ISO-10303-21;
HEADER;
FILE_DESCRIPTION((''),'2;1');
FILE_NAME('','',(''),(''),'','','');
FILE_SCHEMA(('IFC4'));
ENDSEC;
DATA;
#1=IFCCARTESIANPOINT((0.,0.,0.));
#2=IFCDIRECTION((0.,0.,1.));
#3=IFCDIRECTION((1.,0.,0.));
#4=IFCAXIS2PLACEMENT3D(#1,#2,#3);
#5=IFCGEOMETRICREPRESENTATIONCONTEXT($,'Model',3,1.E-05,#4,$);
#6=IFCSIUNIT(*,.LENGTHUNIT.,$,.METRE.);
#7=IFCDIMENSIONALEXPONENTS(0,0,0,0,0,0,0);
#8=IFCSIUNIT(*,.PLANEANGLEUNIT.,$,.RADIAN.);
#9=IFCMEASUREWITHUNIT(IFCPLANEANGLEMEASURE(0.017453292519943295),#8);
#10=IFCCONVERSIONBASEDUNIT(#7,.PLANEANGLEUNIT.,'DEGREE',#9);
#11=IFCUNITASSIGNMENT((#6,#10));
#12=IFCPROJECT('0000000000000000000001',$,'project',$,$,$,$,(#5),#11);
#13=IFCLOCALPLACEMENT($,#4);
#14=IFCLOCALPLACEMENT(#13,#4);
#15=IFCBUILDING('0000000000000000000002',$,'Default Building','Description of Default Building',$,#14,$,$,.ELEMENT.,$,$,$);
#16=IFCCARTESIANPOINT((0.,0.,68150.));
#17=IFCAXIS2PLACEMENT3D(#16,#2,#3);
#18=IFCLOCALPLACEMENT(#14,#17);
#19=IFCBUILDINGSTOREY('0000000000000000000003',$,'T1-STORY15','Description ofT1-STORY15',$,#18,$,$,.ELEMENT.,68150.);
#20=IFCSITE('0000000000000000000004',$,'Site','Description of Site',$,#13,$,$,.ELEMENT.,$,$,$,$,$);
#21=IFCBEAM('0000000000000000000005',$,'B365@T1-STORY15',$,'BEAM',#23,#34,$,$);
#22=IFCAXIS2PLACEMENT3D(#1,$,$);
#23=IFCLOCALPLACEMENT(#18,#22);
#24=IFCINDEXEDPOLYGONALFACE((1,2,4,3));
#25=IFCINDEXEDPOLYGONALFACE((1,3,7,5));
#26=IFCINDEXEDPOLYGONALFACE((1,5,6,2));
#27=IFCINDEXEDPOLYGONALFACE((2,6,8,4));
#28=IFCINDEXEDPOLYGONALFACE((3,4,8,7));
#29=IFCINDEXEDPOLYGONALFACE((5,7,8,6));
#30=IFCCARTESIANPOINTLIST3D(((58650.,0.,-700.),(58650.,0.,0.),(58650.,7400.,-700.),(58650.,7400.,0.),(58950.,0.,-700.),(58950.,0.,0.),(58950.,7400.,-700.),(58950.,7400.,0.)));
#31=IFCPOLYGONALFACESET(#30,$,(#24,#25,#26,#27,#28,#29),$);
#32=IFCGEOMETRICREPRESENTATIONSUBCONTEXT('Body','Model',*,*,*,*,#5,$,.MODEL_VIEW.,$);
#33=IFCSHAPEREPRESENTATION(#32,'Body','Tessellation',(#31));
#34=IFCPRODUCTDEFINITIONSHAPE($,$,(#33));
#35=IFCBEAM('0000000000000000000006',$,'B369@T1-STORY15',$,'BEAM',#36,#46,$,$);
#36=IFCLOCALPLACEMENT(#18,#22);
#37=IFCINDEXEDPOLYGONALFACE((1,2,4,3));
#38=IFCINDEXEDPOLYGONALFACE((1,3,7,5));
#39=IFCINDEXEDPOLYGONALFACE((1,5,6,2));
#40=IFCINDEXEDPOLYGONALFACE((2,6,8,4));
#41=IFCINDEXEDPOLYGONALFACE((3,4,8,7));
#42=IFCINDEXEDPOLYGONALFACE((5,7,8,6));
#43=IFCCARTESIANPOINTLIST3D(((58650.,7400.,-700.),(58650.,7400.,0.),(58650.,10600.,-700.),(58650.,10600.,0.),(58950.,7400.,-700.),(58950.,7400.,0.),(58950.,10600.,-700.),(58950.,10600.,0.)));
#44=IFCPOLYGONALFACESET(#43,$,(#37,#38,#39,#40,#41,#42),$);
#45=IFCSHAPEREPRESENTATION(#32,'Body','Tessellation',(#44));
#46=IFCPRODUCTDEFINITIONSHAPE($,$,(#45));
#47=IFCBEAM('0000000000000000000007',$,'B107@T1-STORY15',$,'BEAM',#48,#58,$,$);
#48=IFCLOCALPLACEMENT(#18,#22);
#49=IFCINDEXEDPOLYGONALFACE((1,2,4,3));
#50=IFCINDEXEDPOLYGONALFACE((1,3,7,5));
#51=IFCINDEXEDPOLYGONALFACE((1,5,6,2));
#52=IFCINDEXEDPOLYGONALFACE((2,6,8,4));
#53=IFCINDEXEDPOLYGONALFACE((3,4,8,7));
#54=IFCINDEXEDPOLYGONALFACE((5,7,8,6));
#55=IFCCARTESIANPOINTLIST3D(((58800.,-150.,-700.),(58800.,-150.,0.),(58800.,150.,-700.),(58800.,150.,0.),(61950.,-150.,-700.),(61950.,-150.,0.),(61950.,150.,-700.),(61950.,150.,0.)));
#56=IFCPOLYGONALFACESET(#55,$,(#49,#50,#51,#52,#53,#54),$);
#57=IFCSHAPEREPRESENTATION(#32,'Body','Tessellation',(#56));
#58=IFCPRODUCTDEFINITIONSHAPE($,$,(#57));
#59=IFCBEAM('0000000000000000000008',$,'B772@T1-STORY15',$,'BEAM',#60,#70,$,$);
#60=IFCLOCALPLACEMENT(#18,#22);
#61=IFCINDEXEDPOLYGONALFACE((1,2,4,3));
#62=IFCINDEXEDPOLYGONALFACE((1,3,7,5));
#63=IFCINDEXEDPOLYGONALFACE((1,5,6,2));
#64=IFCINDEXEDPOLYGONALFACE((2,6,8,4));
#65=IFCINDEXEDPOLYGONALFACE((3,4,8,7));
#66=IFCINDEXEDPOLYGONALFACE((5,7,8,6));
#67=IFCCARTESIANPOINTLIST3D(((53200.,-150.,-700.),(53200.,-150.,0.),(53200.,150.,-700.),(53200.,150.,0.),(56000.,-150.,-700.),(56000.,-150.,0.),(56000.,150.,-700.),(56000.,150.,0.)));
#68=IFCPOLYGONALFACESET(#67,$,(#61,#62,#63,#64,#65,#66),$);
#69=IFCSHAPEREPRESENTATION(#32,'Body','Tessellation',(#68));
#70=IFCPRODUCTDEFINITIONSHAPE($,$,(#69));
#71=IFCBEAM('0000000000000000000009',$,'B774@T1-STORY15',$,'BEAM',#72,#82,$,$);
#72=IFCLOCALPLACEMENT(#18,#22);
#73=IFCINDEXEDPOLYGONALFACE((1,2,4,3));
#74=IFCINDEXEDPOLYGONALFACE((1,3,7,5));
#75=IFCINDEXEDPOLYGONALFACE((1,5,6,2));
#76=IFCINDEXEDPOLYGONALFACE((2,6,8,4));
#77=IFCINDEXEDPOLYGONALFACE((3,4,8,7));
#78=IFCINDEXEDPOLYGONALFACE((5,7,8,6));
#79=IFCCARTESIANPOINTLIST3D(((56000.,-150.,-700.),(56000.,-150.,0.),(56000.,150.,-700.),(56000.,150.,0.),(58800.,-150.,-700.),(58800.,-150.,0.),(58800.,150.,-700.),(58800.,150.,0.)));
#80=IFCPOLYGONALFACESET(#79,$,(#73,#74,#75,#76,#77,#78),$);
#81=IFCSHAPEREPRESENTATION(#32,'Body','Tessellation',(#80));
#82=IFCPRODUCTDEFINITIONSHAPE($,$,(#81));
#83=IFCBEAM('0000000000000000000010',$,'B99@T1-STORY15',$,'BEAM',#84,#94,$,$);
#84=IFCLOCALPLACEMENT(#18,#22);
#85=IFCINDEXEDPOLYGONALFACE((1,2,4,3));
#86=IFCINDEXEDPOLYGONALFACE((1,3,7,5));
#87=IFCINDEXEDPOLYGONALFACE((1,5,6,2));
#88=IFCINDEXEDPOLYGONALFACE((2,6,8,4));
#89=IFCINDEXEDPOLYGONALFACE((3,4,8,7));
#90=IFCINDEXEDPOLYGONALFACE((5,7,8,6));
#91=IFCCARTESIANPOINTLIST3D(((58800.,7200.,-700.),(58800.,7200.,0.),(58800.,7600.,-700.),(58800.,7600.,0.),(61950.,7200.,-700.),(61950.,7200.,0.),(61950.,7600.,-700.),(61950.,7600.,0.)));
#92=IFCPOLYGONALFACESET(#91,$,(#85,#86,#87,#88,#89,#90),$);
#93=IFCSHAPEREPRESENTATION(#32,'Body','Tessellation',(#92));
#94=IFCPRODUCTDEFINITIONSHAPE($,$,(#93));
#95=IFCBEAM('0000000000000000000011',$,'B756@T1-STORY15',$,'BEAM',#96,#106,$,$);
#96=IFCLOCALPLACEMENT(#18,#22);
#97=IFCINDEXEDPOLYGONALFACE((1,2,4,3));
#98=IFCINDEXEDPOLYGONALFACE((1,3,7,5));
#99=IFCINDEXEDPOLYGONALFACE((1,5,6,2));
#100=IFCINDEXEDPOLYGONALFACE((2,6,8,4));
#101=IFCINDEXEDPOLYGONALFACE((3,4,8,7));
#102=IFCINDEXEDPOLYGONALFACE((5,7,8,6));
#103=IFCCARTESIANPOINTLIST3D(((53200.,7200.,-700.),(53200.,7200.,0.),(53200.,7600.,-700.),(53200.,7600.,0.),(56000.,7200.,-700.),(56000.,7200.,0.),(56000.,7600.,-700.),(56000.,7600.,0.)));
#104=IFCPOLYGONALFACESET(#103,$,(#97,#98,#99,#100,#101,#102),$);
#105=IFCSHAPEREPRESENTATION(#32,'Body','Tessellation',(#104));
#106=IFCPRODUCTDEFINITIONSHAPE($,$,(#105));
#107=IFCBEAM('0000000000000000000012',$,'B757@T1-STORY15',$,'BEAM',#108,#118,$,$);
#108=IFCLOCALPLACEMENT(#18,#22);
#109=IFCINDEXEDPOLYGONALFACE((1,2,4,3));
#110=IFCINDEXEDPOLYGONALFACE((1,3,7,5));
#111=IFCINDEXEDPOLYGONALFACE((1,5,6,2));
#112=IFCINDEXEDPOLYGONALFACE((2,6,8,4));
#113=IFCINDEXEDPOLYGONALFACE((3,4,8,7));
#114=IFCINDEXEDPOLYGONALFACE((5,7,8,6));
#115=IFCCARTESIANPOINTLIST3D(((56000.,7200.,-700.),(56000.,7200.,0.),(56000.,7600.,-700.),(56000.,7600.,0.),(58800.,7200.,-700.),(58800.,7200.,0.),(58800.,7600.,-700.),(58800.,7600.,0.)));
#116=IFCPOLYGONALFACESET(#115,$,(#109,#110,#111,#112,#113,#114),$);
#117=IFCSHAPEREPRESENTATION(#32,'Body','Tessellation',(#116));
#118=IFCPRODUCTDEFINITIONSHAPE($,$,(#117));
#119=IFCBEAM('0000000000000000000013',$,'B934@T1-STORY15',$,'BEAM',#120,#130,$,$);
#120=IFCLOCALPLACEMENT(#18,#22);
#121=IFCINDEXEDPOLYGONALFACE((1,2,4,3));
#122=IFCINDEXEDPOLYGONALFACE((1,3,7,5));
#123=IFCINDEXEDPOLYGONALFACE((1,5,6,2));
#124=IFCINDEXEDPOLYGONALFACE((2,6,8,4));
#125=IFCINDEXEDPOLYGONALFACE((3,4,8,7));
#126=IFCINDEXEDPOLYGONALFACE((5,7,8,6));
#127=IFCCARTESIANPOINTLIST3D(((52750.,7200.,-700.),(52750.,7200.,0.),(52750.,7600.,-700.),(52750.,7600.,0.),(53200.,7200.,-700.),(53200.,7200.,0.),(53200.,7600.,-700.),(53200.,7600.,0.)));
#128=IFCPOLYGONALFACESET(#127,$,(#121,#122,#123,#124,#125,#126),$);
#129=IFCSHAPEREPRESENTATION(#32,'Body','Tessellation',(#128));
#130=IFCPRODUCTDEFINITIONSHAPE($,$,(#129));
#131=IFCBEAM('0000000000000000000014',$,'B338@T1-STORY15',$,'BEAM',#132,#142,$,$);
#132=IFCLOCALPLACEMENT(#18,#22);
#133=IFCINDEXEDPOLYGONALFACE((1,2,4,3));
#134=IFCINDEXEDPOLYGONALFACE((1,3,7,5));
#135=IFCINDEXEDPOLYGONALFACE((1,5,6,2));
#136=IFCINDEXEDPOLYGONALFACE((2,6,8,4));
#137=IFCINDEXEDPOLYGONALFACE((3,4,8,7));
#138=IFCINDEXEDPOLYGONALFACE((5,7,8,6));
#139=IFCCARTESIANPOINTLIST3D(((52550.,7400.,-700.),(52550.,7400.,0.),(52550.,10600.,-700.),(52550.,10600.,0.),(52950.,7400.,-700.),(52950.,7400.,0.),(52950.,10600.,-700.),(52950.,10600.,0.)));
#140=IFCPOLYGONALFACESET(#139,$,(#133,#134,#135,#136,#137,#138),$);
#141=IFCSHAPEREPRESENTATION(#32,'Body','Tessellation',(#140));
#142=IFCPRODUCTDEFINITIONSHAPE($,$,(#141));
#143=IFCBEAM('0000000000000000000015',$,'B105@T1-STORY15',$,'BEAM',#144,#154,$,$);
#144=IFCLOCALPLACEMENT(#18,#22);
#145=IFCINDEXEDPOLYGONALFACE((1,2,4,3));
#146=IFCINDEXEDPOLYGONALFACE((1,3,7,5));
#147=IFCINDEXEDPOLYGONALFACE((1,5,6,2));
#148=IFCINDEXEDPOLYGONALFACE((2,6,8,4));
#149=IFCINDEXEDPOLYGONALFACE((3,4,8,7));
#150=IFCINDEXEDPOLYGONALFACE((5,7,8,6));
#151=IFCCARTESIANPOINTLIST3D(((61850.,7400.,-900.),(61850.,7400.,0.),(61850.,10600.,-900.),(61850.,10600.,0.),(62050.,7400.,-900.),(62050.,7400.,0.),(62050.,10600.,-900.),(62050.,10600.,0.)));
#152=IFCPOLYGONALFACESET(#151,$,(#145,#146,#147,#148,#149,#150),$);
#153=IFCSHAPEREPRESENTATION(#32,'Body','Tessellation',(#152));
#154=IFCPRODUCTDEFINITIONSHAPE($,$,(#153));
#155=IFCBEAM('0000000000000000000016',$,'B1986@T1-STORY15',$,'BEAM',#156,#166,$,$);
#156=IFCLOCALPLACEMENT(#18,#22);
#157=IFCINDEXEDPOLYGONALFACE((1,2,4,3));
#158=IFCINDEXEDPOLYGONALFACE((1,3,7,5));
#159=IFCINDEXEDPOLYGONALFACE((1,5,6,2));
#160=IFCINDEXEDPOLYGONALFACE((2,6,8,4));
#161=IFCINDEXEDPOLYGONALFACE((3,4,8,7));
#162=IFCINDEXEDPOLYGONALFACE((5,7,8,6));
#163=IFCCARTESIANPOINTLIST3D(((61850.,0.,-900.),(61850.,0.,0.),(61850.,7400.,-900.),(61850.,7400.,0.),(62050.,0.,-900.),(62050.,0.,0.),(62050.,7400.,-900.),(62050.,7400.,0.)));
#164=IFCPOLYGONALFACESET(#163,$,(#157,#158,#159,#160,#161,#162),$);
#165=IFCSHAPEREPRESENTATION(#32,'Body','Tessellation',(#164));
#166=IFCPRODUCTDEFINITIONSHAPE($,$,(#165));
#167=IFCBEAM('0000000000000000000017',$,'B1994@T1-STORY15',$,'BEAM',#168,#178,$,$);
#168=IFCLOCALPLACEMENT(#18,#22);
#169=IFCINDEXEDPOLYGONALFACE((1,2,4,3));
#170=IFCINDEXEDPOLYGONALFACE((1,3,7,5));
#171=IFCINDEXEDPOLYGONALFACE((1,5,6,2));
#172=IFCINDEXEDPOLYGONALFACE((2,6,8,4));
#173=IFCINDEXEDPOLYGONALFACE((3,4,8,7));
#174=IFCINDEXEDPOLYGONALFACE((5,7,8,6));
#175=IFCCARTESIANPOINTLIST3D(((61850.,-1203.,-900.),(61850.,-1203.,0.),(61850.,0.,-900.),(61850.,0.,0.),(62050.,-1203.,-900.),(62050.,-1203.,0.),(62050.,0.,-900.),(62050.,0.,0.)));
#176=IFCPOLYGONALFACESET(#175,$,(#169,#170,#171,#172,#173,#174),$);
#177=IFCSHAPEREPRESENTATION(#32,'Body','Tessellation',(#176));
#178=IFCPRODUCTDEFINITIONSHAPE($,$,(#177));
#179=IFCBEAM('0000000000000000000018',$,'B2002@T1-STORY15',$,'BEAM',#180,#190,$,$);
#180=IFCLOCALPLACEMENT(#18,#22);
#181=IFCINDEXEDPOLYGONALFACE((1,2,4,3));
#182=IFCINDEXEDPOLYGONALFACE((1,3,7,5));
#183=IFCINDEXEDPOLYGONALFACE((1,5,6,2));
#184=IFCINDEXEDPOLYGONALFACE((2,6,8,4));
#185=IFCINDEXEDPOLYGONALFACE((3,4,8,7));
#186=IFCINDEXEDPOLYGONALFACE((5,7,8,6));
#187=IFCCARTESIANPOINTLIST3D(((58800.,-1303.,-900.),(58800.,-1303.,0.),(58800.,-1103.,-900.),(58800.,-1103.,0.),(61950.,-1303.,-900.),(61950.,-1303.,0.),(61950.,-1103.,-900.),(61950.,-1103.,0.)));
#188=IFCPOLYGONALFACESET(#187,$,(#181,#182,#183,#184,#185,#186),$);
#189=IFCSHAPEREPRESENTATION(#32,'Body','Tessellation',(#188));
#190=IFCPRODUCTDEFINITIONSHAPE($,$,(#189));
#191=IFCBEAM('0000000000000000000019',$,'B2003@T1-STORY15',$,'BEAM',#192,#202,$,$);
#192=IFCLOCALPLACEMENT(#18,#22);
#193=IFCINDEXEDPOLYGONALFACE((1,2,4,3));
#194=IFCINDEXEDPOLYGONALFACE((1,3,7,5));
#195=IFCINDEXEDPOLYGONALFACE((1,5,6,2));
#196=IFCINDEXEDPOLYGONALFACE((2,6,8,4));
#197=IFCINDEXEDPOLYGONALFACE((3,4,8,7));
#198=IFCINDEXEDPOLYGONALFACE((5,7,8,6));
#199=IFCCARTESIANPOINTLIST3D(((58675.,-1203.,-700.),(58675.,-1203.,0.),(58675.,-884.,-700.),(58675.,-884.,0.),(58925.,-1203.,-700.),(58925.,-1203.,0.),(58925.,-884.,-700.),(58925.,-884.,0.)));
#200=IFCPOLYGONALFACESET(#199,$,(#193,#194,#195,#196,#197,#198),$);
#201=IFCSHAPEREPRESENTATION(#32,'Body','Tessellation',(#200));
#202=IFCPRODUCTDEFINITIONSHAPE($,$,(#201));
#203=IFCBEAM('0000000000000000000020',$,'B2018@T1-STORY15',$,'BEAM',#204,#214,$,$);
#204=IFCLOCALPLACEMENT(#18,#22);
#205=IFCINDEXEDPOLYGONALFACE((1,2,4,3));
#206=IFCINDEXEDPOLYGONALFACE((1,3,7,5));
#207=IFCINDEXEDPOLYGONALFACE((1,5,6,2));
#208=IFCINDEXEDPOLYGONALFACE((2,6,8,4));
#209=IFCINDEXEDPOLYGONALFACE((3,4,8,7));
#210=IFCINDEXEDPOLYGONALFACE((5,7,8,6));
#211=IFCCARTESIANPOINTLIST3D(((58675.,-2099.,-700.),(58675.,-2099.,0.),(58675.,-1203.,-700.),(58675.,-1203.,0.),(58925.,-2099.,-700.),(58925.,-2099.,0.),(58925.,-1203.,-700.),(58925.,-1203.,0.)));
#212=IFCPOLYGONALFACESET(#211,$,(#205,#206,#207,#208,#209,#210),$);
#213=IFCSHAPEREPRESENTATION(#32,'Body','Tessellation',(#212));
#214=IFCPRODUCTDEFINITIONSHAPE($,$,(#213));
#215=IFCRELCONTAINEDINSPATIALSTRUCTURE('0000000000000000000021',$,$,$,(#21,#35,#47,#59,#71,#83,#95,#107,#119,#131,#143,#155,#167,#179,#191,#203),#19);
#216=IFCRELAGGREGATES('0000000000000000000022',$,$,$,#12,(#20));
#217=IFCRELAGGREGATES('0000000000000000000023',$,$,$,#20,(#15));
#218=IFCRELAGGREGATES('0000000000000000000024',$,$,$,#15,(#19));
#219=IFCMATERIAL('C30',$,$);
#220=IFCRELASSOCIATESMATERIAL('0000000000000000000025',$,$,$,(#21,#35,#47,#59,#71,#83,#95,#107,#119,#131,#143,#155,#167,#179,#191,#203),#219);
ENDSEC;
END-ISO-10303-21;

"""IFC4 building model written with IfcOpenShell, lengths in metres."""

from ifc_helpers import new_model, entity, si_unit, converted_unit, frame, origin_with_axes, place, context, subcontext, project, spatial, rectangle, extrude, material, element, save


model = new_model("IFC4")

# Units and contexts
model_context = context("Model", 3, precision=1e-05, world=origin_with_axes())
body_context = subcontext(model_context, "Body", "Model", "MODEL_VIEW")
ifc_project = project(units=[si_unit("LENGTHUNIT", "METRE"), converted_unit("PLANEANGLEUNIT", "DEGREE", entity("IfcPlaneAngleMeasure", 0.017453292519943295), si_unit("PLANEANGLEUNIT", "RADIAN"), dimensions=[0, 0, 0, 0, 0, 0, 0])], contexts=[model_context])

# Site, building, storey
site_placement = place(None, origin_with_axes())
site = spatial("IfcSite", under=ifc_project, at=site_placement, Name="Site", Description="Description of Site", CompositionType="ELEMENT")
building_placement = place(site_placement, origin_with_axes())
building = spatial("IfcBuilding", under=site, at=building_placement, Name="Default Building", Description="Description of Default Building", CompositionType="ELEMENT")
storey_placement = place(building_placement, frame((0.0, 0.0, 68150.0), z_axis=(0.0, 0.0, 1.0), x_axis=(1.0, 0.0, 0.0)))
storey = spatial("IfcBuildingStorey", under=building, at=storey_placement, Name="T1-STORY15", Description="Description ofT1-STORY15", CompositionType="ELEMENT", Elevation=68150.0)

# Beams
ifc_material_1 = material(Name="C30")
beam_1_placement = place(storey_placement, frame((58800.0, 0.0, -350.0), z_axis=(0.0, 1.0, 0.0), x_axis=(-1.0, 0.0, 0.0)))
element("IfcBeam", 1, at=beam_1_placement, inside=storey, material=ifc_material_1, Name="B365@T1-STORY15", ObjectType="BEAM", context=body_context, shape_type="SweptSolid", body=[
    extrude(rectangle(XDim=300.0, YDim=700.0), origin_with_axes(), (0.0, 0.0, 1.0), 7400.0),
])
beam_2_placement = place(storey_placement, frame((58800.0, 7400.0, -350.0), z_axis=(0.0, 1.0, 0.0), x_axis=(-1.0, 0.0, 0.0)))
element("IfcBeam", 2, at=beam_2_placement, inside=storey, material=ifc_material_1, Name="B369@T1-STORY15", ObjectType="BEAM", context=body_context, shape_type="SweptSolid", body=[
    extrude(rectangle(XDim=300.0, YDim=700.0), origin_with_axes(), (0.0, 0.0, 1.0), 3200.0),
])
beam_3_placement = place(storey_placement, frame((58800.0, 0.0, -350.0), z_axis=(1.0, 0.0, 0.0), x_axis=(0.0, 1.0, 0.0)))
element("IfcBeam", 3, at=beam_3_placement, inside=storey, material=ifc_material_1, Name="B107@T1-STORY15", ObjectType="BEAM", context=body_context, shape_type="SweptSolid", body=[
    extrude(rectangle(XDim=300.0, YDim=700.0), origin_with_axes(), (0.0, 0.0, 1.0), 3150.0),
])
for number, where, z_axis, x_axis, name in (
    (4, (53200.0, 0.0, -350.0), (1.0, 0.0, 0.0), (0.0, 1.0, 0.0), "B772@T1-STORY15"),
    (5, (56000.0, 0.0, -350.0), (1.0, 0.0, 0.0), (0.0, 1.0, 0.0), "B774@T1-STORY15"),
):
    element("IfcBeam", number, at=place(storey_placement, frame(where, z_axis=z_axis, x_axis=x_axis)), inside=storey, material=ifc_material_1, Name=name, ObjectType="BEAM", context=body_context, shape_type="SweptSolid", body=[
        extrude(rectangle(XDim=300.0, YDim=700.0), origin_with_axes(), (0.0, 0.0, 1.0), 2800.0),
    ])
beam_4_placement = place(storey_placement, frame((58800.0, 7400.0, -350.0), z_axis=(1.0, 0.0, 0.0), x_axis=(0.0, 1.0, 0.0)))
element("IfcBeam", 6, at=beam_4_placement, inside=storey, material=ifc_material_1, Name="B99@T1-STORY15", ObjectType="BEAM", context=body_context, shape_type="SweptSolid", body=[
    extrude(rectangle(XDim=400.0, YDim=700.0), origin_with_axes(), (0.0, 0.0, 1.0), 3150.0),
])
for number, where, z_axis, x_axis, name in (
    (7, (53200.0, 7400.0, -350.0), (1.0, 0.0, 0.0), (0.0, 1.0, 0.0), "B756@T1-STORY15"),
    (8, (56000.0, 7400.0, -350.0), (1.0, 0.0, 0.0), (0.0, 1.0, 0.0), "B757@T1-STORY15"),
):
    element("IfcBeam", number, at=place(storey_placement, frame(where, z_axis=z_axis, x_axis=x_axis)), inside=storey, material=ifc_material_1, Name=name, ObjectType="BEAM", context=body_context, shape_type="SweptSolid", body=[
        extrude(rectangle(XDim=400.0, YDim=700.0), origin_with_axes(), (0.0, 0.0, 1.0), 2800.0),
    ])
beam_5_placement = place(storey_placement, frame((52750.0, 7400.0, -350.0), z_axis=(1.0, 0.0, 0.0), x_axis=(0.0, 1.0, 0.0)))
element("IfcBeam", 9, at=beam_5_placement, inside=storey, material=ifc_material_1, Name="B934@T1-STORY15", ObjectType="BEAM", context=body_context, shape_type="SweptSolid", body=[
    extrude(rectangle(XDim=400.0, YDim=700.0), origin_with_axes(), (0.0, 0.0, 1.0), 450.0),
])
beam_6_placement = place(storey_placement, frame((52750.0, 7400.0, -350.0), z_axis=(0.0, 1.0, 0.0), x_axis=(-1.0, 0.0, 0.0)))
element("IfcBeam", 10, at=beam_6_placement, inside=storey, material=ifc_material_1, Name="B338@T1-STORY15", ObjectType="BEAM", context=body_context, shape_type="SweptSolid", body=[
    extrude(rectangle(XDim=400.0, YDim=700.0), origin_with_axes(), (0.0, 0.0, 1.0), 3200.0),
])
beam_7_placement = place(storey_placement, frame((61950.0, 7400.0, -450.0), z_axis=(0.0, 1.0, 0.0), x_axis=(-1.0, 0.0, 0.0)))
element("IfcBeam", 11, at=beam_7_placement, inside=storey, material=ifc_material_1, Name="B105@T1-STORY15", ObjectType="BEAM", context=body_context, shape_type="SweptSolid", body=[
    extrude(rectangle(XDim=200.0, YDim=900.0), origin_with_axes(), (0.0, 0.0, 1.0), 3200.0),
])
beam_8_placement = place(storey_placement, frame((61950.0, 0.0, -450.0), z_axis=(0.0, 1.0, 0.0), x_axis=(-1.0, 0.0, 0.0)))
element("IfcBeam", 12, at=beam_8_placement, inside=storey, material=ifc_material_1, Name="B1986@T1-STORY15", ObjectType="BEAM", context=body_context, shape_type="SweptSolid", body=[
    extrude(rectangle(XDim=200.0, YDim=900.0), origin_with_axes(), (0.0, 0.0, 1.0), 7400.0),
])
beam_9_placement = place(storey_placement, frame((61950.0, -1203.0, -450.0), z_axis=(0.0, 1.0, 0.0), x_axis=(-1.0, 0.0, 0.0)))
element("IfcBeam", 13, at=beam_9_placement, inside=storey, material=ifc_material_1, Name="B1994@T1-STORY15", ObjectType="BEAM", context=body_context, shape_type="SweptSolid", body=[
    extrude(rectangle(XDim=200.0, YDim=900.0), origin_with_axes(), (0.0, 0.0, 1.0), 1203.0),
])
beam_10_placement = place(storey_placement, frame((58800.0, -1203.0, -450.0), z_axis=(1.0, 0.0, 0.0), x_axis=(0.0, 1.0, 0.0)))
element("IfcBeam", 14, at=beam_10_placement, inside=storey, material=ifc_material_1, Name="B2002@T1-STORY15", ObjectType="BEAM", context=body_context, shape_type="SweptSolid", body=[
    extrude(rectangle(XDim=200.0, YDim=900.0), origin_with_axes(), (0.0, 0.0, 1.0), 3150.0),
])
beam_11_placement = place(storey_placement, frame((58800.0, -1203.0, -350.0), z_axis=(0.0, 1.0, 0.0), x_axis=(-1.0, 0.0, 0.0)))
element("IfcBeam", 15, at=beam_11_placement, inside=storey, material=ifc_material_1, Name="B2003@T1-STORY15", ObjectType="BEAM", context=body_context, shape_type="SweptSolid", body=[
    extrude(rectangle(XDim=250.0, YDim=700.0), origin_with_axes(), (0.0, 0.0, 1.0), 319.0),
])
beam_12_placement = place(storey_placement, frame((58800.0, -2099.0, -350.0), z_axis=(0.0, 1.0, 0.0), x_axis=(-1.0, 0.0, 0.0)))
element("IfcBeam", 16, at=beam_12_placement, inside=storey, material=ifc_material_1, Name="B2018@T1-STORY15", ObjectType="BEAM", context=body_context, shape_type="SweptSolid", body=[
    extrude(rectangle(XDim=250.0, YDim=700.0), origin_with_axes(), (0.0, 0.0, 1.0), 896.0),
])

save(model, "model.ifc")
